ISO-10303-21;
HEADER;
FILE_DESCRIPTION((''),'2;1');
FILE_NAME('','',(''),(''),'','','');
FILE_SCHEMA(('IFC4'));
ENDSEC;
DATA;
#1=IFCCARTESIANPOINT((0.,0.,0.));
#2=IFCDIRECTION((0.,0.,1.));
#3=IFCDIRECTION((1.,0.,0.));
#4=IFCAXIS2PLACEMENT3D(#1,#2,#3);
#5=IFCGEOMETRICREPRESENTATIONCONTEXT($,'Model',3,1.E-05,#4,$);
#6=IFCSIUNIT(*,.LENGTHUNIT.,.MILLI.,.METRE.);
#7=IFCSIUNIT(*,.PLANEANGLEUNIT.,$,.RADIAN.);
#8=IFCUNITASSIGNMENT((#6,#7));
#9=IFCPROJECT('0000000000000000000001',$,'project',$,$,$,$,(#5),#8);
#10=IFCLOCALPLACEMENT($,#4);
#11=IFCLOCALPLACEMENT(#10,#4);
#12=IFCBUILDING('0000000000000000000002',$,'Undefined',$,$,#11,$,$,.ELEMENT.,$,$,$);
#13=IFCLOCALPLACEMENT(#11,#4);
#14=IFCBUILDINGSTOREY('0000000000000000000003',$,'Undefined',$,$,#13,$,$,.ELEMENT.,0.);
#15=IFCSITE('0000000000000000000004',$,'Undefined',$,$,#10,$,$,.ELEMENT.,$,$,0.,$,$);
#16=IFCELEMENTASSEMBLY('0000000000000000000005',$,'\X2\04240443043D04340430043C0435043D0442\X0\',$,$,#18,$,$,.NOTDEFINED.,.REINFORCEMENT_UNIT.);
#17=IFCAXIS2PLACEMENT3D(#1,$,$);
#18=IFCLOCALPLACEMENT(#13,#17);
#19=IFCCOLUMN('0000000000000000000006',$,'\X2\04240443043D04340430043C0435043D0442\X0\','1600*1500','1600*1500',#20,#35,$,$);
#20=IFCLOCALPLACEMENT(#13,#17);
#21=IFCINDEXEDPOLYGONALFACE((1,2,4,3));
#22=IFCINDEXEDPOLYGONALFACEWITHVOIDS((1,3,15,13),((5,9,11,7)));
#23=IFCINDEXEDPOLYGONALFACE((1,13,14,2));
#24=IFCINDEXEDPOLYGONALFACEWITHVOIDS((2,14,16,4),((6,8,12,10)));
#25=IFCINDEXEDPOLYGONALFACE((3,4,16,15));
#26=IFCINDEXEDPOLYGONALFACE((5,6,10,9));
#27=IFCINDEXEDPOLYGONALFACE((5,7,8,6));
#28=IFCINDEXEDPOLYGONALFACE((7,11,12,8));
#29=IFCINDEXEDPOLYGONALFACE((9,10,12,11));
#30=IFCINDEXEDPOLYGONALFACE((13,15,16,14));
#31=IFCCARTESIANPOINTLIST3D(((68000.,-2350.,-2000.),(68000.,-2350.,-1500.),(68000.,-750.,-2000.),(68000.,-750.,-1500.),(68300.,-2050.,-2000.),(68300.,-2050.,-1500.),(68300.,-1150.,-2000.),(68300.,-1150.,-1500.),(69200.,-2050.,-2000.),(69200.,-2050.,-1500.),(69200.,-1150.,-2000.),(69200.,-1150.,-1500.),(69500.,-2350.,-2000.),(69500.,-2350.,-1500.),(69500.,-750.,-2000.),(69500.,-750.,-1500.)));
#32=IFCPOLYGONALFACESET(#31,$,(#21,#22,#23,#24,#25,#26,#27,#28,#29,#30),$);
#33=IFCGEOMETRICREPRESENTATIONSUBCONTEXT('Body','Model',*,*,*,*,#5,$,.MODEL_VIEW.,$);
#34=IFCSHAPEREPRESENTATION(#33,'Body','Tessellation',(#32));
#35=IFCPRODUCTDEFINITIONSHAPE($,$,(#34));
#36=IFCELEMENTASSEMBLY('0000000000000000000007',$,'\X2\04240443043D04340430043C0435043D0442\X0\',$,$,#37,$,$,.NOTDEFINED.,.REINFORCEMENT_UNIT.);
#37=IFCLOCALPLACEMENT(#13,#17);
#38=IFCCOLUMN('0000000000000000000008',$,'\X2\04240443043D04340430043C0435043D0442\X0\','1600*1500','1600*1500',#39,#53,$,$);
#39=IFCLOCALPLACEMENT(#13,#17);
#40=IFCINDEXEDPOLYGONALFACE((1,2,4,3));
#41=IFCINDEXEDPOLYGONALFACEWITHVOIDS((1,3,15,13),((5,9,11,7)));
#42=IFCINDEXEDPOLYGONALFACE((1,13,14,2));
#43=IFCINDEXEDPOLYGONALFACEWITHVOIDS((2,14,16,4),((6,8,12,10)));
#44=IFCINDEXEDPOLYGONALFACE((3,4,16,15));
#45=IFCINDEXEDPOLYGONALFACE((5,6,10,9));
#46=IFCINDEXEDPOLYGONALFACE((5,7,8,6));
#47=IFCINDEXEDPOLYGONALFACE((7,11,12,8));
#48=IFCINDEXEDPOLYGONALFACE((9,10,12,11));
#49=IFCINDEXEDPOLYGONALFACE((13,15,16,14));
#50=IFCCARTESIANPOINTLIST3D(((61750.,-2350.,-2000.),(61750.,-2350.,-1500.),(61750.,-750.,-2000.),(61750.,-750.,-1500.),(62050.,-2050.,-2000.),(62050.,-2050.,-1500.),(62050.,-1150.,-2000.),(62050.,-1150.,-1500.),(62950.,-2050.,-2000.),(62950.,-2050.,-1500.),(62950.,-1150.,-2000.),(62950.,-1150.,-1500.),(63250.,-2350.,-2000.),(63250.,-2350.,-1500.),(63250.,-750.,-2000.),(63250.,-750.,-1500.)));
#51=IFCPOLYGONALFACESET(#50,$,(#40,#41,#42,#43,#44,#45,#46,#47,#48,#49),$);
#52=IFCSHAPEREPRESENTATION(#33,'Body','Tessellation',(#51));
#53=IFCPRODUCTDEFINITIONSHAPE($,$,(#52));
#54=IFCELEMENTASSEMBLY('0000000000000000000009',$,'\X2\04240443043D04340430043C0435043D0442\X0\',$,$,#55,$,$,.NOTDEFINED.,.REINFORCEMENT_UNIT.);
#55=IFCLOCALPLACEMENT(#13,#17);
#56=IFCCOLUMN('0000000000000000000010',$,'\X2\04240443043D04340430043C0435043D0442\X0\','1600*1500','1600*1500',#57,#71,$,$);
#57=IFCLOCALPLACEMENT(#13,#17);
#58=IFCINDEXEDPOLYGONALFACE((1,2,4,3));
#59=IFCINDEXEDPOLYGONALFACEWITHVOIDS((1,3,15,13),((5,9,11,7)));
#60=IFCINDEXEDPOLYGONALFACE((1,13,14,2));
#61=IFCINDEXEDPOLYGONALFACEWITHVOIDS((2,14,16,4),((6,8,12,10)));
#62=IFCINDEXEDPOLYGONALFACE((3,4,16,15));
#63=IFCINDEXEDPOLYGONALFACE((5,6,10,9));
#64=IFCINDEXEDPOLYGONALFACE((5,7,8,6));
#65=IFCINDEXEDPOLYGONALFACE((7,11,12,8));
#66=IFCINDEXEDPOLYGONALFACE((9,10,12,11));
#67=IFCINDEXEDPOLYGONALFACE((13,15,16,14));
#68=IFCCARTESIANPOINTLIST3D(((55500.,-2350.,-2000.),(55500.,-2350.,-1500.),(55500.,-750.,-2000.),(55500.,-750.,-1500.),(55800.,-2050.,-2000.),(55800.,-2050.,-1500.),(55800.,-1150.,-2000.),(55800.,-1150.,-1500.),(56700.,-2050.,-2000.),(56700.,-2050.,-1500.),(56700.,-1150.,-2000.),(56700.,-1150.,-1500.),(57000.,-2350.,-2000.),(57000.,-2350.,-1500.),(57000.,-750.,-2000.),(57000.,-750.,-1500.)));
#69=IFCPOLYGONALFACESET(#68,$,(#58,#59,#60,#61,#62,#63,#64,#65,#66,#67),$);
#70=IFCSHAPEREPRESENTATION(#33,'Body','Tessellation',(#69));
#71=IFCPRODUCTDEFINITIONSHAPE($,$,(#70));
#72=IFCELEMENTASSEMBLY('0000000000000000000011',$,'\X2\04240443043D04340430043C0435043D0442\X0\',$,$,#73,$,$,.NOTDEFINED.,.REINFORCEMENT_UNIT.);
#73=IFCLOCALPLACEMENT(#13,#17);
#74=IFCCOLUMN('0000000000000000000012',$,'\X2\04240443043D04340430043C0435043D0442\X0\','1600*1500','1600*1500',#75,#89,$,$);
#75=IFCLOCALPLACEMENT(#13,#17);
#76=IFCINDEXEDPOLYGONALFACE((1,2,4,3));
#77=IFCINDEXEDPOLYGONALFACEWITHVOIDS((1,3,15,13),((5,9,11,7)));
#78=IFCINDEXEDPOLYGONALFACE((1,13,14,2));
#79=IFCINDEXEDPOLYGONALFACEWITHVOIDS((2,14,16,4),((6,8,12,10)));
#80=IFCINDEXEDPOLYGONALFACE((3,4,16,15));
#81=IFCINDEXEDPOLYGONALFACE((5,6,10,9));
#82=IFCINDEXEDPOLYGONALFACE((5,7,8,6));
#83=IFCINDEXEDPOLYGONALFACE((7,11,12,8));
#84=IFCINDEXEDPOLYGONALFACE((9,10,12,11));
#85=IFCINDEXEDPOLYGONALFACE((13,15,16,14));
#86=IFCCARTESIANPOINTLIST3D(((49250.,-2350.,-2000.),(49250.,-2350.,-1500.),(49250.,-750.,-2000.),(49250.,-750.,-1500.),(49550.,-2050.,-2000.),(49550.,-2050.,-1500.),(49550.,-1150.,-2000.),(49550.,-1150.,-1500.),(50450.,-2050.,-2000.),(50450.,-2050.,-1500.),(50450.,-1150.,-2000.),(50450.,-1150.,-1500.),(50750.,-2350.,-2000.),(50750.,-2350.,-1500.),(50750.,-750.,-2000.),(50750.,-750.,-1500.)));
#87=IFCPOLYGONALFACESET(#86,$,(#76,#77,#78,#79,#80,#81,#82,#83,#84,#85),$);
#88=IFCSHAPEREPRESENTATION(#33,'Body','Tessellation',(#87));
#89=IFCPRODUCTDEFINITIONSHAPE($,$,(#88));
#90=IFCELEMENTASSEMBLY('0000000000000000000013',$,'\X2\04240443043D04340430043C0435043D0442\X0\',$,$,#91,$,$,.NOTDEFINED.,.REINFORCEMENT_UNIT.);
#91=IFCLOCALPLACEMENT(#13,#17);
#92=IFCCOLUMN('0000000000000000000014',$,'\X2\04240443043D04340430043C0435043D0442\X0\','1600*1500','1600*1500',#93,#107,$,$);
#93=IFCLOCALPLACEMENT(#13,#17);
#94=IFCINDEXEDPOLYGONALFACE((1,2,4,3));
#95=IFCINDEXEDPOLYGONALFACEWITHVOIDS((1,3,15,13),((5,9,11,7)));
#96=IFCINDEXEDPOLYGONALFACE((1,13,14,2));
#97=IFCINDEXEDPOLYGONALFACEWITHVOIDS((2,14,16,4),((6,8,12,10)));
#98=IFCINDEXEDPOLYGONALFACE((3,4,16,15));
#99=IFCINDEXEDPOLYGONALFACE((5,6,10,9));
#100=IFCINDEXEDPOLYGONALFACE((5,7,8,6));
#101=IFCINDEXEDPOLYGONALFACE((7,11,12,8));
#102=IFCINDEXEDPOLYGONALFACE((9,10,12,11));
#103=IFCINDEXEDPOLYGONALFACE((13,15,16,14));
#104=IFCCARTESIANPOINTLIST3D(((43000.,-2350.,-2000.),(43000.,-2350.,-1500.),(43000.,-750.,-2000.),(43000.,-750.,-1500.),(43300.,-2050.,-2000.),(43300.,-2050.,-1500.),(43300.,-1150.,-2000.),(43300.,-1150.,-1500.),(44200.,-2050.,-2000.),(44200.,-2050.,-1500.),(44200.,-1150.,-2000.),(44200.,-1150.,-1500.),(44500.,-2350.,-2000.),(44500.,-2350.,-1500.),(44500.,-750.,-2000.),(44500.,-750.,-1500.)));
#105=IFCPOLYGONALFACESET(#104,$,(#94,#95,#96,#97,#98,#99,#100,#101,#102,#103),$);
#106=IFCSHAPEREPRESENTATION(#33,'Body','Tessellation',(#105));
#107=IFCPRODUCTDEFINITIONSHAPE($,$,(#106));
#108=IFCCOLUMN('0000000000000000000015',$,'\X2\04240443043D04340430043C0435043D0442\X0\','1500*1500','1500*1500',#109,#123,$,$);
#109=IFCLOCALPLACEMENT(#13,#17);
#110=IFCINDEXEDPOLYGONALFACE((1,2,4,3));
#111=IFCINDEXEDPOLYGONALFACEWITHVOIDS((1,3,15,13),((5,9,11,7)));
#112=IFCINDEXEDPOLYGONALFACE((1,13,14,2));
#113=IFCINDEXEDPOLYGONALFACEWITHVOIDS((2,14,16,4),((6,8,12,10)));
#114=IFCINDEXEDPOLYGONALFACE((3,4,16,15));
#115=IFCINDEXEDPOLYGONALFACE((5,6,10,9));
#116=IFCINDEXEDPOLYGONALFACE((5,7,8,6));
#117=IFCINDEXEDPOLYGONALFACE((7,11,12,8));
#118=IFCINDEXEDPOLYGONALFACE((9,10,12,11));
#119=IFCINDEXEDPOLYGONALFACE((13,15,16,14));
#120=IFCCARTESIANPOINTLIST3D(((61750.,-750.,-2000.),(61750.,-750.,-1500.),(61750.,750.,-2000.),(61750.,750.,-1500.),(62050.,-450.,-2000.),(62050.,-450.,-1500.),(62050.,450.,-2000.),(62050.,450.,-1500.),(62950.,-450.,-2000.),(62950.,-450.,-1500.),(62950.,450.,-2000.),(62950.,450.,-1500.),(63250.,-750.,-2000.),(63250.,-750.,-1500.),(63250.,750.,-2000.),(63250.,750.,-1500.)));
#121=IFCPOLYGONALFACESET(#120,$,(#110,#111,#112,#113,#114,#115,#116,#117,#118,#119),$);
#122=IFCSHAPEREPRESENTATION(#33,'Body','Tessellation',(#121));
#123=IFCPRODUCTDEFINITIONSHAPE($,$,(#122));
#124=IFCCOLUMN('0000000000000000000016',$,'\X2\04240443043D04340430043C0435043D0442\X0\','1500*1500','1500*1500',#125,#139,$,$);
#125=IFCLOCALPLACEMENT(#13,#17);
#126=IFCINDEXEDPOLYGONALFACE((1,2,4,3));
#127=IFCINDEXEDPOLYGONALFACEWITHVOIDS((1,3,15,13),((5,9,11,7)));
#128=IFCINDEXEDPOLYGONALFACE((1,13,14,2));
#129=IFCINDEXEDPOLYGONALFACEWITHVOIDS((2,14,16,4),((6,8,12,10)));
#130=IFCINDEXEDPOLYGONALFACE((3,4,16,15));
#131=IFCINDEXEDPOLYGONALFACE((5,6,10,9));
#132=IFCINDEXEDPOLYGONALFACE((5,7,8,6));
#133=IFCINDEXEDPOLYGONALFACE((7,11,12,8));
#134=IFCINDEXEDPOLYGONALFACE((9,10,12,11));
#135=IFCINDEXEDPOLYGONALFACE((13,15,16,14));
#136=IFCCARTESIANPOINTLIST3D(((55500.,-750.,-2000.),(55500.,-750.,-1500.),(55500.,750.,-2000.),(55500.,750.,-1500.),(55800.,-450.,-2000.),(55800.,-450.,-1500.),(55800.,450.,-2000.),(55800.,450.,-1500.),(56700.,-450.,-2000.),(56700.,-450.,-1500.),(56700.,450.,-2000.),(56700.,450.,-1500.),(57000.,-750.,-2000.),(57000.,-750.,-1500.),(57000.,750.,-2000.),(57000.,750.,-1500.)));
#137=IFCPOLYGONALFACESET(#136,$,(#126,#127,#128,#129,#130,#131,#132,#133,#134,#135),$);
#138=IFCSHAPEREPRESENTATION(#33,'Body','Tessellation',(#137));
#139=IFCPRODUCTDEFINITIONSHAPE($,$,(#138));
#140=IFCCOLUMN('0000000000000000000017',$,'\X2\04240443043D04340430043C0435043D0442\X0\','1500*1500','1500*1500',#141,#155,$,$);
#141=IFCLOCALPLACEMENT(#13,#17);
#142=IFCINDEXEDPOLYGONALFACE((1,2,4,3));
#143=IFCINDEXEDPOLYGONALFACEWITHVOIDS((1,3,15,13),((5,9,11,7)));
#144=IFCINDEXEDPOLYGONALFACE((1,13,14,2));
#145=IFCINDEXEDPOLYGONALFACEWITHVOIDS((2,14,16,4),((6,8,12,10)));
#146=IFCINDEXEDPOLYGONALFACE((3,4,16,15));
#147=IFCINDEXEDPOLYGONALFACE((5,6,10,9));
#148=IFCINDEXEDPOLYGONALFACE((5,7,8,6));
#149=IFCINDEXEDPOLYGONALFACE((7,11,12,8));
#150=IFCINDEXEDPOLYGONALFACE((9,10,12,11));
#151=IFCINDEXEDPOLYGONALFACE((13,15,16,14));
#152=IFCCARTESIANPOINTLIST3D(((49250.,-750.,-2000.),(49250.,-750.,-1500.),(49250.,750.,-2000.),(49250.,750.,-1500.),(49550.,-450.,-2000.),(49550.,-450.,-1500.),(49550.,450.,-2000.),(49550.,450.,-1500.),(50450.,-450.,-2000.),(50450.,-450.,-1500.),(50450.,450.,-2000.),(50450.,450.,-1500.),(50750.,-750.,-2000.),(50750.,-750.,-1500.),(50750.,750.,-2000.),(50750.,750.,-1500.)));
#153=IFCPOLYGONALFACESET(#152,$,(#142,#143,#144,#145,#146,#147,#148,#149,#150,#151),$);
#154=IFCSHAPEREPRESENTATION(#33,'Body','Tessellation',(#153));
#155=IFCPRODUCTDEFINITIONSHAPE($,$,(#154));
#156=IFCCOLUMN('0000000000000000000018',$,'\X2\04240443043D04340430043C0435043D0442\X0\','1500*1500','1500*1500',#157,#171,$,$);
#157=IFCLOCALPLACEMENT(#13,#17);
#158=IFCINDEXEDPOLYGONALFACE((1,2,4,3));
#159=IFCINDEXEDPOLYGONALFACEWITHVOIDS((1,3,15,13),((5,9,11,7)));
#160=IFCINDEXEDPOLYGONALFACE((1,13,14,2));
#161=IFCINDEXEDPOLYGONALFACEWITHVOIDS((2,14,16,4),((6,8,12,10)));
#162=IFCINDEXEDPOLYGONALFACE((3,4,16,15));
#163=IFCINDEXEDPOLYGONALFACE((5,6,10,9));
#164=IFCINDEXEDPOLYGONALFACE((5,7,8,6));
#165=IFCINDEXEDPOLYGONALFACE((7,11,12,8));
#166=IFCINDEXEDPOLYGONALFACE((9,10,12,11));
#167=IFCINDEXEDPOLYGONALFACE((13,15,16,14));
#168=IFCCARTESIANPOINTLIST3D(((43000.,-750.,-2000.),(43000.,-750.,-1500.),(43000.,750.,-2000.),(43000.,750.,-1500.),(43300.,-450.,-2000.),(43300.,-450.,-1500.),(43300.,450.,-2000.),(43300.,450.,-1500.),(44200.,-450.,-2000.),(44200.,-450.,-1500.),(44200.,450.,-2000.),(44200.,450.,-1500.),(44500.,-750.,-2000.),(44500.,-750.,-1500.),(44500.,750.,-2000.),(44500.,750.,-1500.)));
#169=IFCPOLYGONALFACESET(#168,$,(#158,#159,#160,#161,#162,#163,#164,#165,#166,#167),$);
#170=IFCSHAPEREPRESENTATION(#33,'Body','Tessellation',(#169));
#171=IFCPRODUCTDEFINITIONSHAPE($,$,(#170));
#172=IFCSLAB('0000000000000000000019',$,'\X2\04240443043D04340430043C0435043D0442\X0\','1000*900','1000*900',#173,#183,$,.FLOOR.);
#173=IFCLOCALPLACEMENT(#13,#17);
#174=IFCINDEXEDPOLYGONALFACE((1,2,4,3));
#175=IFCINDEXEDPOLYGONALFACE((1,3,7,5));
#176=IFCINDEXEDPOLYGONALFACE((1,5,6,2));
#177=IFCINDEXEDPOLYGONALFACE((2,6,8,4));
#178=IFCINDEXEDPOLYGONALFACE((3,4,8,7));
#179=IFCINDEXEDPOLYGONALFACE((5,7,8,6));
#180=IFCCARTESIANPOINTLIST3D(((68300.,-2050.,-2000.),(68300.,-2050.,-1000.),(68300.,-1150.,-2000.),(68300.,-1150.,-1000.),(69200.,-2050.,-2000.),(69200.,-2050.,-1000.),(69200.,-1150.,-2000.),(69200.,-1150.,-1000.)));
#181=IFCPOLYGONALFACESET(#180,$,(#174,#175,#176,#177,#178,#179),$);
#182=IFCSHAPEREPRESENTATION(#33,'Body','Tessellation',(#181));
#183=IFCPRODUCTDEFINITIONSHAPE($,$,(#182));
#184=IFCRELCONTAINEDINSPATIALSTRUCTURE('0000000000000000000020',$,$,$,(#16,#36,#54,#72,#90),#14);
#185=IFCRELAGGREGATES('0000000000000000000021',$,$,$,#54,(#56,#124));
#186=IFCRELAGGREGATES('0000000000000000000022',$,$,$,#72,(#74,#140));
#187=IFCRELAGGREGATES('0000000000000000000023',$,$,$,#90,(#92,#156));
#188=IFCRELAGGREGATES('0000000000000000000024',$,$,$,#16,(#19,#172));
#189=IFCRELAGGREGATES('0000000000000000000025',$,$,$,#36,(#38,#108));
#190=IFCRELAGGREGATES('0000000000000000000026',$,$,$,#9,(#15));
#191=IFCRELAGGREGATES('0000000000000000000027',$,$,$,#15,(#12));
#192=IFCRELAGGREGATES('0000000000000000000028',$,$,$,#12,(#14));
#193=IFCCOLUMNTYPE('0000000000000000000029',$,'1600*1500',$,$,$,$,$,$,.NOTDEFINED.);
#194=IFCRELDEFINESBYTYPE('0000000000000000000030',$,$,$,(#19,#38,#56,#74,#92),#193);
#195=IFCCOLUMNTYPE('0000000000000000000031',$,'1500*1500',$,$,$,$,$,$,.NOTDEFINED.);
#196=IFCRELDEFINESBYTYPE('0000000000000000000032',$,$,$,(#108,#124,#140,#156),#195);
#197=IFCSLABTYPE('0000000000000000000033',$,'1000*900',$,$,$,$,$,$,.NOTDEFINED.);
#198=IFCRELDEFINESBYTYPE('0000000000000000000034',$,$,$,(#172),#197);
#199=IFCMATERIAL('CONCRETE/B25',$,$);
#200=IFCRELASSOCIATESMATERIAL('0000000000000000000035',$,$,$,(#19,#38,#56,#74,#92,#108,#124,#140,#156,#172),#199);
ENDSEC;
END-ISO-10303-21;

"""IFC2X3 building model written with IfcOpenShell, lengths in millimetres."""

from ifc_helpers import new_model, si_unit, frame, origin_with_axes, origin_2d_with_axis, place, context, subcontext, project, spatial, polyline, rectangle, outline, extrude, boolean, material, type_object, element, aggregate, save


model = new_model("IFC2X3")

# Units and contexts
model_context = context("Model", 3, precision=1e-05, world=origin_with_axes())
body_context = subcontext(model_context, "Body", "Model", "MODEL_VIEW")
ifc_project = project(units=[si_unit("LENGTHUNIT", "METRE", prefix="MILLI"), si_unit("PLANEANGLEUNIT", "RADIAN")], contexts=[model_context])

# Site, building, storey
site_placement = place(None, origin_with_axes())
site = spatial("IfcSite", under=ifc_project, at=site_placement, Name="Undefined", CompositionType="ELEMENT", RefElevation=0.0)
building_placement = place(site_placement, origin_with_axes())
building = spatial("IfcBuilding", under=site, at=building_placement, Name="Undefined", CompositionType="ELEMENT")
storey_placement = place(building_placement, origin_with_axes())
storey = spatial("IfcBuildingStorey", under=building, at=storey_placement, Name="Undefined", CompositionType="ELEMENT", Elevation=0.0)

# Element assemblies, columns
assembly_1_placement = place(storey_placement, origin_with_axes())
assembly_1 = element("IfcElementAssembly", 1, at=assembly_1_placement, inside=storey, Name="Фундамент", AssemblyPlace="NOTDEFINED", PredefinedType="REINFORCEMENT_UNIT")
ifc_material = material(Name="CONCRETE/B25")
column_type_1 = type_object("IfcColumnType", Name="1600*1500", PredefinedType="NOTDEFINED")
column_1_placement = place(assembly_1_placement, frame((68750.0, -1550.0, -2000.0), z_axis=(0.0, 0.0, 1.0), x_axis=(0.0, -1.0, 0.0)))
column_1 = element("IfcColumn", 2, at=column_1_placement, type_object=column_type_1, material=ifc_material, Name="Фундамент", Description="1600*1500", ObjectType="1600*1500", context=body_context, shape_type="CSG", body=[
    boolean("DIFFERENCE", extrude(rectangle(XDim=1500.0, YDim=1600.0, at=origin_2d_with_axis()), frame((0.0, 0.0, 500.0), z_axis=(0.0, 0.0, -1.0), x_axis=(0.0, 1.0, 0.0)), (0.0, 0.0, 1.0), 500.0), extrude(outline(polyline([(0.0, 0.0), (900.0, 0.0), (900.0, 900.0), (0.0, 900.0), (0.0, 0.0)])), frame((-400.0, -450.0, -100.0), z_axis=(0.0, 0.0, 1.0), x_axis=(1.0, 0.0, 0.0)), (0.0, 0.0, 1.0), 700.0)),
])
assembly_2_placement = place(storey_placement, origin_with_axes())
assembly_2 = element("IfcElementAssembly", 3, at=assembly_2_placement, inside=storey, Name="Фундамент", AssemblyPlace="NOTDEFINED", PredefinedType="REINFORCEMENT_UNIT")
column_2_placement = place(assembly_2_placement, frame((62500.0, -1550.0, -2000.0), z_axis=(0.0, 0.0, 1.0), x_axis=(0.0, -1.0, 0.0)))
column_2 = element("IfcColumn", 4, at=column_2_placement, type_object=column_type_1, material=ifc_material, Name="Фундамент", Description="1600*1500", ObjectType="1600*1500", context=body_context, shape_type="CSG", body=[
    boolean("DIFFERENCE", extrude(rectangle(XDim=1500.0, YDim=1600.0, at=origin_2d_with_axis()), frame((0.0, 0.0, 500.0), z_axis=(0.0, 0.0, -1.0), x_axis=(0.0, 1.0, 0.0)), (0.0, 0.0, 1.0), 500.0), extrude(outline(polyline([(0.0, 0.0), (900.0, 0.0), (900.0, 900.0), (0.0, 900.0), (0.0, 0.0)])), frame((-400.0, -450.0, -100.0), z_axis=(0.0, 0.0, 1.0), x_axis=(1.0, 0.0, 0.0)), (0.0, 0.0, 1.0), 700.0)),
])
assembly_3_placement = place(storey_placement, origin_with_axes())
assembly_3 = element("IfcElementAssembly", 5, at=assembly_3_placement, inside=storey, Name="Фундамент", AssemblyPlace="NOTDEFINED", PredefinedType="REINFORCEMENT_UNIT")
column_3_placement = place(assembly_3_placement, frame((56250.0, -1550.0, -2000.0), z_axis=(0.0, 0.0, 1.0), x_axis=(0.0, -1.0, 0.0)))
column_3 = element("IfcColumn", 6, at=column_3_placement, type_object=column_type_1, material=ifc_material, Name="Фундамент", Description="1600*1500", ObjectType="1600*1500", context=body_context, shape_type="CSG", body=[
    boolean("DIFFERENCE", extrude(rectangle(XDim=1500.0, YDim=1600.0, at=origin_2d_with_axis()), frame((0.0, 0.0, 500.0), z_axis=(0.0, 0.0, -1.0), x_axis=(0.0, 1.0, 0.0)), (0.0, 0.0, 1.0), 500.0), extrude(outline(polyline([(0.0, 0.0), (900.0, 0.0), (900.0, 900.0), (0.0, 900.0), (0.0, 0.0)])), frame((-400.0, -450.0, -100.0), z_axis=(0.0, 0.0, 1.0), x_axis=(1.0, 0.0, 0.0)), (0.0, 0.0, 1.0), 700.0)),
])
assembly_4_placement = place(storey_placement, origin_with_axes())
assembly_4 = element("IfcElementAssembly", 7, at=assembly_4_placement, inside=storey, Name="Фундамент", AssemblyPlace="NOTDEFINED", PredefinedType="REINFORCEMENT_UNIT")
column_4_placement = place(assembly_4_placement, frame((50000.0, -1550.0, -2000.0), z_axis=(0.0, 0.0, 1.0), x_axis=(0.0, -1.0, 0.0)))
column_4 = element("IfcColumn", 8, at=column_4_placement, type_object=column_type_1, material=ifc_material, Name="Фундамент", Description="1600*1500", ObjectType="1600*1500", context=body_context, shape_type="CSG", body=[
    boolean("DIFFERENCE", extrude(rectangle(XDim=1500.0, YDim=1600.0, at=origin_2d_with_axis()), frame((0.0, 0.0, 500.0), z_axis=(0.0, 0.0, -1.0), x_axis=(0.0, 1.0, 0.0)), (0.0, 0.0, 1.0), 500.0), extrude(outline(polyline([(0.0, 0.0), (900.0, 0.0), (900.0, 900.0), (0.0, 900.0), (0.0, 0.0)])), frame((-400.0, -450.0, -100.0), z_axis=(0.0, 0.0, 1.0), x_axis=(1.0, 0.0, 0.0)), (0.0, 0.0, 1.0), 700.0)),
])
assembly_5_placement = place(storey_placement, origin_with_axes())
assembly_5 = element("IfcElementAssembly", 9, at=assembly_5_placement, inside=storey, Name="Фундамент", AssemblyPlace="NOTDEFINED", PredefinedType="REINFORCEMENT_UNIT")
column_5_placement = place(assembly_5_placement, frame((43750.0, -1550.0, -2000.0), z_axis=(0.0, 0.0, 1.0), x_axis=(0.0, -1.0, 0.0)))
column_5 = element("IfcColumn", 10, at=column_5_placement, type_object=column_type_1, material=ifc_material, Name="Фундамент", Description="1600*1500", ObjectType="1600*1500", context=body_context, shape_type="CSG", body=[
    boolean("DIFFERENCE", extrude(rectangle(XDim=1500.0, YDim=1600.0, at=origin_2d_with_axis()), frame((0.0, 0.0, 500.0), z_axis=(0.0, 0.0, -1.0), x_axis=(0.0, 1.0, 0.0)), (0.0, 0.0, 1.0), 500.0), extrude(outline(polyline([(0.0, 0.0), (900.0, 0.0), (900.0, 900.0), (0.0, 900.0), (0.0, 0.0)])), frame((-400.0, -450.0, -100.0), z_axis=(0.0, 0.0, 1.0), x_axis=(1.0, 0.0, 0.0)), (0.0, 0.0, 1.0), 700.0)),
])

# Columns
column_type_2 = type_object("IfcColumnType", Name="1500*1500", PredefinedType="NOTDEFINED")
column_6_placement = place(assembly_2_placement, frame((62500.0, 0.0, -2000.0), z_axis=(0.0, 0.0, 1.0), x_axis=(0.0, -1.0, 0.0)))
column_6 = element("IfcColumn", 11, at=column_6_placement, type_object=column_type_2, material=ifc_material, Name="Фундамент", Description="1500*1500", ObjectType="1500*1500", context=body_context, shape_type="CSG", body=[
    boolean("DIFFERENCE", extrude(rectangle(XDim=1500.0, YDim=1500.0, at=origin_2d_with_axis()), frame((0.0, 0.0, 500.0), z_axis=(0.0, 0.0, -1.0), x_axis=(0.0, 1.0, 0.0)), (0.0, 0.0, 1.0), 500.0), extrude(outline(polyline([(0.0, 0.0), (900.0, 0.0), (900.0, 900.0), (0.0, 900.0), (0.0, 0.0)])), frame((-450.0, -450.0, -100.0), z_axis=(0.0, 0.0, 1.0), x_axis=(1.0, 0.0, 0.0)), (0.0, 0.0, 1.0), 700.0)),
])
column_7_placement = place(assembly_3_placement, frame((56250.0, 0.0, -2000.0), z_axis=(0.0, 0.0, 1.0), x_axis=(0.0, -1.0, 0.0)))
column_7 = element("IfcColumn", 12, at=column_7_placement, type_object=column_type_2, material=ifc_material, Name="Фундамент", Description="1500*1500", ObjectType="1500*1500", context=body_context, shape_type="CSG", body=[
    boolean("DIFFERENCE", extrude(rectangle(XDim=1500.0, YDim=1500.0, at=origin_2d_with_axis()), frame((0.0, 0.0, 500.0), z_axis=(0.0, 0.0, -1.0), x_axis=(0.0, 1.0, 0.0)), (0.0, 0.0, 1.0), 500.0), extrude(outline(polyline([(0.0, 0.0), (900.0, 0.0), (900.0, 900.0), (0.0, 900.0), (0.0, 0.0)])), frame((-450.0, -450.0, -100.0), z_axis=(0.0, 0.0, 1.0), x_axis=(1.0, 0.0, 0.0)), (0.0, 0.0, 1.0), 700.0)),
])
column_8_placement = place(assembly_4_placement, frame((50000.0, 0.0, -2000.0), z_axis=(0.0, 0.0, 1.0), x_axis=(0.0, -1.0, 0.0)))
column_8 = element("IfcColumn", 13, at=column_8_placement, type_object=column_type_2, material=ifc_material, Name="Фундамент", Description="1500*1500", ObjectType="1500*1500", context=body_context, shape_type="CSG", body=[
    boolean("DIFFERENCE", extrude(rectangle(XDim=1500.0, YDim=1500.0, at=origin_2d_with_axis()), frame((0.0, 0.0, 500.0), z_axis=(0.0, 0.0, -1.0), x_axis=(0.0, 1.0, 0.0)), (0.0, 0.0, 1.0), 500.0), extrude(outline(polyline([(0.0, 0.0), (900.0, 0.0), (900.0, 900.0), (0.0, 900.0), (0.0, 0.0)])), frame((-450.0, -450.0, -100.0), z_axis=(0.0, 0.0, 1.0), x_axis=(1.0, 0.0, 0.0)), (0.0, 0.0, 1.0), 700.0)),
])
column_9_placement = place(assembly_5_placement, frame((43750.0, 0.0, -2000.0), z_axis=(0.0, 0.0, 1.0), x_axis=(0.0, -1.0, 0.0)))
column_9 = element("IfcColumn", 14, at=column_9_placement, type_object=column_type_2, material=ifc_material, Name="Фундамент", Description="1500*1500", ObjectType="1500*1500", context=body_context, shape_type="CSG", body=[
    boolean("DIFFERENCE", extrude(rectangle(XDim=1500.0, YDim=1500.0, at=origin_2d_with_axis()), frame((0.0, 0.0, 500.0), z_axis=(0.0, 0.0, -1.0), x_axis=(0.0, 1.0, 0.0)), (0.0, 0.0, 1.0), 500.0), extrude(outline(polyline([(0.0, 0.0), (900.0, 0.0), (900.0, 900.0), (0.0, 900.0), (0.0, 0.0)])), frame((-450.0, -450.0, -100.0), z_axis=(0.0, 0.0, 1.0), x_axis=(1.0, 0.0, 0.0)), (0.0, 0.0, 1.0), 700.0)),
])

# Slab
slab_type_1 = type_object("IfcSlabType", Name="1000*900", PredefinedType="NOTDEFINED")
slab_1_placement = place(assembly_1_placement, frame((68300.0, -1150.0, -1500.0), z_axis=(0.0, 0.0, 1.0), x_axis=(0.0, -1.0, 0.0)))
slab_1 = element("IfcSlab", 15, at=slab_1_placement, type_object=slab_type_1, material=ifc_material, Name="Фундамент", Description="1000*900", ObjectType="1000*900", PredefinedType="FLOOR", context=body_context, shape_type="SweptSolid", body=[
    extrude(outline(polyline([(0.0, 0.0), (900.0, 0.0), (900.0, 900.0), (0.0, 900.0), (0.0, 0.0)])), frame((0.0, 0.0, -500.0), z_axis=(0.0, 0.0, 1.0), x_axis=(1.0, 0.0, 0.0)), (0.0, 0.0, 1.0), 1000.0),
])
aggregate(assembly_3, [column_3, column_7])
aggregate(assembly_4, [column_4, column_8])
aggregate(assembly_5, [column_5, column_9])
aggregate(assembly_1, [column_1, slab_1])
aggregate(assembly_2, [column_2, column_6])

save(model, "model.ifc")
